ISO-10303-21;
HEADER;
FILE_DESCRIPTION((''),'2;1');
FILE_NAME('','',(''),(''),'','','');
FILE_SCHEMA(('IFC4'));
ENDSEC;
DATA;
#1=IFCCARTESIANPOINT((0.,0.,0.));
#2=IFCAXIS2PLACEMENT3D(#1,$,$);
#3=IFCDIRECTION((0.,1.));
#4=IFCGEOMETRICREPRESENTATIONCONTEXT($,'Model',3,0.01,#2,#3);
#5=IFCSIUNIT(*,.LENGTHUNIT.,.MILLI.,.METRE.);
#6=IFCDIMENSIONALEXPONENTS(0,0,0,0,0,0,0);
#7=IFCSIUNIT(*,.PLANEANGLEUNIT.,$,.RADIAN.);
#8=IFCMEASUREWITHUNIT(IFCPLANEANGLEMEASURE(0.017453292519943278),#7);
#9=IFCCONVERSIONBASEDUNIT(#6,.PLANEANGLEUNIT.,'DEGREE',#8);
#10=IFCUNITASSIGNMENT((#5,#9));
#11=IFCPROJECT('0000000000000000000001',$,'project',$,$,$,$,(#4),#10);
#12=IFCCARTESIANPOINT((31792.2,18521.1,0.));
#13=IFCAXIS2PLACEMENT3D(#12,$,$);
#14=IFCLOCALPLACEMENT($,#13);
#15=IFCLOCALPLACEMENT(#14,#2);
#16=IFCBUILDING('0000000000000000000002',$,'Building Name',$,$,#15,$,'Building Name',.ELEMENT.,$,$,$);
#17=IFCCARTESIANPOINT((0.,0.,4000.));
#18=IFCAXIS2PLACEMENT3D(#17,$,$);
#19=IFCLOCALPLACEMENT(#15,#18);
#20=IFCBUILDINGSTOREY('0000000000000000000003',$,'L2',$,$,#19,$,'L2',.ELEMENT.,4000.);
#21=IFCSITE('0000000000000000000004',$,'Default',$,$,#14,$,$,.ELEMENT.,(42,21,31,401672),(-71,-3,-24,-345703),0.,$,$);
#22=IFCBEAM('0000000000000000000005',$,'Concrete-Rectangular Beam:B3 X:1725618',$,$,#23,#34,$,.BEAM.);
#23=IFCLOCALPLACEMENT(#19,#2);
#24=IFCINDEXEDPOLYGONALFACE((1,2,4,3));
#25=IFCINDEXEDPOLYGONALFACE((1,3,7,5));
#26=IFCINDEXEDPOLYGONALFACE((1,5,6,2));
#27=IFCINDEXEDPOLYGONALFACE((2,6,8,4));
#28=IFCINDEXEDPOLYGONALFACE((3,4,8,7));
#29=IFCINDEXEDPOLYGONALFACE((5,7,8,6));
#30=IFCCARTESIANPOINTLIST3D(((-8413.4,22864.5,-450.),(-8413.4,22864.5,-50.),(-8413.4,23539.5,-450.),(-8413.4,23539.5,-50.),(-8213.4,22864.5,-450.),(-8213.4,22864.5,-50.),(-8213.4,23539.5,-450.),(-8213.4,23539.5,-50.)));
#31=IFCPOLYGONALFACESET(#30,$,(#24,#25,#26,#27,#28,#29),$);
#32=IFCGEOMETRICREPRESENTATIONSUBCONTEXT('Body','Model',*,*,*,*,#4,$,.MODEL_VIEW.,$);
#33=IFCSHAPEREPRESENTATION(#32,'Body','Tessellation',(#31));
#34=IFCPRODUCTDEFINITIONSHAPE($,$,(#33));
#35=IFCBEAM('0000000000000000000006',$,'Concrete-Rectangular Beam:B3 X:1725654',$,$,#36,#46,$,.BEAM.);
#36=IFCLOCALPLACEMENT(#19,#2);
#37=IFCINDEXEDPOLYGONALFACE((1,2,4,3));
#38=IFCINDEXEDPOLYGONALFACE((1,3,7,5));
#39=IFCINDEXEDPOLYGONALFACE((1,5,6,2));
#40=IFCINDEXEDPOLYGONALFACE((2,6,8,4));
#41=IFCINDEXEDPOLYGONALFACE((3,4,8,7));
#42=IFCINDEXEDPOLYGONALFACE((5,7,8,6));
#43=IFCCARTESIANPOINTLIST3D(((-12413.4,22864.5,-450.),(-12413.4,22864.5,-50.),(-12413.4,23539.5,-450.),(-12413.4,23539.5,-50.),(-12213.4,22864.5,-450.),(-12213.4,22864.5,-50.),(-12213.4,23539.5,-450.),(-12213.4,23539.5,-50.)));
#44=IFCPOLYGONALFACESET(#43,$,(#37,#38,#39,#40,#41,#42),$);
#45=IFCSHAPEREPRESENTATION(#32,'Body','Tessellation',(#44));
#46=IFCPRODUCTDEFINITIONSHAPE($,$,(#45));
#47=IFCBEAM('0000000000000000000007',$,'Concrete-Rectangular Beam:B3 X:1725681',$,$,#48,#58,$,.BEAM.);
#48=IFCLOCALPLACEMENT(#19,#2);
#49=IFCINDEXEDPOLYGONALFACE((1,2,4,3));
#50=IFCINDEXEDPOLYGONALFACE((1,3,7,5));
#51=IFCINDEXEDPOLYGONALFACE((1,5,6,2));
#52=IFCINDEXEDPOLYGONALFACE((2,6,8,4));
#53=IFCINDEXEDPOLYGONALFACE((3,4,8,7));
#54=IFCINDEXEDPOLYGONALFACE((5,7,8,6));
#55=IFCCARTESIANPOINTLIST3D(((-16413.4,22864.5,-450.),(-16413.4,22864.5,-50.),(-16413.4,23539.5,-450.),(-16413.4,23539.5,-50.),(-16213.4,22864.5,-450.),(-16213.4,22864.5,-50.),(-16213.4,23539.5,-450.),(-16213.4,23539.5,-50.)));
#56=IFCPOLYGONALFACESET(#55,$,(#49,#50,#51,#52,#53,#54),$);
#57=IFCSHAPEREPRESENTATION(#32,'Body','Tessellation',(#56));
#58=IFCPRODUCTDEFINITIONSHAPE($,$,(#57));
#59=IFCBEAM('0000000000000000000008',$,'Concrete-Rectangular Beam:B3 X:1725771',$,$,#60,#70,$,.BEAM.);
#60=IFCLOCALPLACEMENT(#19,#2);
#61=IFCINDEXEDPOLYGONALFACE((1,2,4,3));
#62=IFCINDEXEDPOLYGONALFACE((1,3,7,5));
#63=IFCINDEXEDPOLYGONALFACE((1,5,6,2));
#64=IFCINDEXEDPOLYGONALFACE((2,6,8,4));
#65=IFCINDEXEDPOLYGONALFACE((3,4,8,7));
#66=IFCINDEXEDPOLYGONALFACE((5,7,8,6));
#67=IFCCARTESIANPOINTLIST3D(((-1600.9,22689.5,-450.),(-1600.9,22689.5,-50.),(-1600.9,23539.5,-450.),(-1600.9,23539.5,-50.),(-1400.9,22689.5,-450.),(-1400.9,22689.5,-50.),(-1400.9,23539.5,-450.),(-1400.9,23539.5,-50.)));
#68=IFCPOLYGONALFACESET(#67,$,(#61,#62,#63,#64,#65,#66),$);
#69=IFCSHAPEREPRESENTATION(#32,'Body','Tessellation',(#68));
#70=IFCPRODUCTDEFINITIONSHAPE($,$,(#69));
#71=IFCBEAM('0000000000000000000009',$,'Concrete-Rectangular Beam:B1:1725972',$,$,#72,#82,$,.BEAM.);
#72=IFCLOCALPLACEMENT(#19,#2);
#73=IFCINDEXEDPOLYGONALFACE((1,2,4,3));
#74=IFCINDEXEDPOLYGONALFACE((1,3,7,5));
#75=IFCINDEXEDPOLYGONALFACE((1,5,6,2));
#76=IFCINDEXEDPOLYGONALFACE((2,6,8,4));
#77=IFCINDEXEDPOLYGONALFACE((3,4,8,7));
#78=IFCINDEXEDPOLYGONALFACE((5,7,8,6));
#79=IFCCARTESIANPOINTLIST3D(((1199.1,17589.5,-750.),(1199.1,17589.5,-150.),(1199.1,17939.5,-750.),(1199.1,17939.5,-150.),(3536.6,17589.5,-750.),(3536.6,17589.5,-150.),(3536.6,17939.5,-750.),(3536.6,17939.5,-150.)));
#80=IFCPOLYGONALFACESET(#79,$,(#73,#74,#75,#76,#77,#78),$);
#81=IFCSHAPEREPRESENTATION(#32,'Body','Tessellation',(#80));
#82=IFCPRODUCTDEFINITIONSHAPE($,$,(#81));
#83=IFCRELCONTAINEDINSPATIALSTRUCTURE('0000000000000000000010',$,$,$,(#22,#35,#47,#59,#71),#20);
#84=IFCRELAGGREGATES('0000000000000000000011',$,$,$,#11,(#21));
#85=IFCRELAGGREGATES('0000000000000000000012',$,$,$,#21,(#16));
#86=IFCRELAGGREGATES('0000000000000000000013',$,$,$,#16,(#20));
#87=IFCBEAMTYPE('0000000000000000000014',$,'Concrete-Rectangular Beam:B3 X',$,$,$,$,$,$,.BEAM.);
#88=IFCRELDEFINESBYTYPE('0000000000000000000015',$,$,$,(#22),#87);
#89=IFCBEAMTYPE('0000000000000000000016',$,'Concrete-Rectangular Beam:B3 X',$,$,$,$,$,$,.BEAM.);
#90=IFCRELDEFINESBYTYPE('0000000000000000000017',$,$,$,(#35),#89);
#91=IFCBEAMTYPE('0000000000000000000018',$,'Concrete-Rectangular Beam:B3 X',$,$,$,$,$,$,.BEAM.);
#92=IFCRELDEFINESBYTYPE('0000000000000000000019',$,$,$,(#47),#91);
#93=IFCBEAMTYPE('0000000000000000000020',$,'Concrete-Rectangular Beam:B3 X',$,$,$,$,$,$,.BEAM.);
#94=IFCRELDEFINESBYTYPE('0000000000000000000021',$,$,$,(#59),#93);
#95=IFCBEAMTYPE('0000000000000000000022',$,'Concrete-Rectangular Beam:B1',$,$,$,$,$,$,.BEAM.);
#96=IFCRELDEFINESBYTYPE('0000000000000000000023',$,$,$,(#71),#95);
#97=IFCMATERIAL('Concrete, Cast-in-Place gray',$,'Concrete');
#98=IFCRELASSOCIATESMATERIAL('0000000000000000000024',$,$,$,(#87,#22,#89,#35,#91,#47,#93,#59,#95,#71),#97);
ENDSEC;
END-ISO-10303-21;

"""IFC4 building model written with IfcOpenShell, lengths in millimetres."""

from ifc_helpers import new_model, entity, si_unit, converted_unit, direction, frame, origin, place, context, subcontext, project, spatial, indexed_curve, outline, extrude, source, transform, mapped, material, type_object, type_shapes, element, save


model = new_model("IFC4")

# Units and contexts
model_context = context("Model", 3, precision=0.01, world=origin(), true_north=direction((0.0, 1.0)))
body_context = subcontext(model_context, "Body", "Model", "MODEL_VIEW")
ifc_project = project(units=[si_unit("LENGTHUNIT", "METRE", prefix="MILLI"), converted_unit("PLANEANGLEUNIT", "DEGREE", entity("IfcPlaneAngleMeasure", 0.017453292519943278), si_unit("PLANEANGLEUNIT", "RADIAN"), dimensions=[0, 0, 0, 0, 0, 0, 0])], contexts=[model_context])

# Site, building, storey
site_placement = place(None, frame((31792.2, 18521.1, 0.0)))
site = spatial("IfcSite", under=ifc_project, at=site_placement, Name="Default", CompositionType="ELEMENT", RefLatitude=(42, 21, 31, 401672), RefLongitude=(-71, -3, -24, -345703), RefElevation=0.0)
building_placement = place(site_placement, origin())
building = spatial("IfcBuilding", under=site, at=building_placement, Name="Building Name", LongName="Building Name", CompositionType="ELEMENT")
storey_placement = place(building_placement, frame((0.0, 0.0, 4000.0)))
storey = spatial("IfcBuildingStorey", under=building, at=storey_placement, Name="L2", LongName="L2", CompositionType="ELEMENT", Elevation=4000.0)

# Shared definitions
ifc_material = material(Name="Concrete, Cast-in-Place gray", Category="Concrete")

# Beams
beam_type_1 = type_object("IfcBeamType", Name="Concrete-Rectangular Beam:B3 X", PredefinedType="BEAM", material=ifc_material)
shared_shape_1 = source(origin(), body_context, "Body", "SweptSolid", [
    extrude(outline(indexed_curve([(-100.0, -200.0), (100.0, -200.0), (100.0, 200.0), (-100.0, 200.0), (-100.0, -200.0)], self_intersect=False)), frame((-8313.4, 23539.5, 3750.0), z_axis=(0.0, -1.0, 0.0), x_axis=(-1.0, 0.0, 0.0)), (0.0, 0.0, 1.0), 675.0),
])
type_shapes(beam_type_1, [shared_shape_1])
beam_1_placement = place(storey_placement, frame((0.0, 0.0, -4000.0)))
element("IfcBeam", 1, at=beam_1_placement, inside=storey, type_object=beam_type_1, material=ifc_material, Name="Concrete-Rectangular Beam:B3 X:1725618", PredefinedType="BEAM", context=body_context, shape_type="MappedRepresentation", body=[
    mapped(shared_shape_1, transform((0.0, 0.0, 0.0), scale=1.0)),
])
beam_type_2 = type_object("IfcBeamType", Name="Concrete-Rectangular Beam:B3 X", PredefinedType="BEAM", material=ifc_material)
shared_shape_2 = source(origin(), body_context, "Body", "SweptSolid", [
    extrude(outline(indexed_curve([(-100.0, -200.0), (100.0, -200.0), (100.0, 200.0), (-100.0, 200.0), (-100.0, -200.0)], self_intersect=False)), frame((-12313.4, 23539.5, 3750.0), z_axis=(0.0, -1.0, 0.0), x_axis=(-1.0, 0.0, 0.0)), (0.0, 0.0, 1.0), 675.0),
])
type_shapes(beam_type_2, [shared_shape_2])
beam_2_placement = place(storey_placement, frame((0.0, 0.0, -4000.0)))
element("IfcBeam", 2, at=beam_2_placement, inside=storey, type_object=beam_type_2, material=ifc_material, Name="Concrete-Rectangular Beam:B3 X:1725654", PredefinedType="BEAM", context=body_context, shape_type="MappedRepresentation", body=[
    mapped(shared_shape_2, transform((0.0, 0.0, 0.0), scale=1.0)),
])
beam_type_3 = type_object("IfcBeamType", Name="Concrete-Rectangular Beam:B3 X", PredefinedType="BEAM", material=ifc_material)
shared_shape_3 = source(origin(), body_context, "Body", "SweptSolid", [
    extrude(outline(indexed_curve([(-100.0, -200.0), (100.0, -200.0), (100.0, 200.0), (-100.0, 200.0), (-100.0, -200.0)], self_intersect=False)), frame((-16313.4, 23539.5, 3750.0), z_axis=(0.0, -1.0, 0.0), x_axis=(-1.0, 0.0, 0.0)), (0.0, 0.0, 1.0), 675.0),
])
type_shapes(beam_type_3, [shared_shape_3])
beam_3_placement = place(storey_placement, frame((0.0, 0.0, -4000.0)))
element("IfcBeam", 3, at=beam_3_placement, inside=storey, type_object=beam_type_3, material=ifc_material, Name="Concrete-Rectangular Beam:B3 X:1725681", PredefinedType="BEAM", context=body_context, shape_type="MappedRepresentation", body=[
    mapped(shared_shape_3, transform((0.0, 0.0, 0.0), scale=1.0)),
])
beam_type_4 = type_object("IfcBeamType", Name="Concrete-Rectangular Beam:B3 X", PredefinedType="BEAM", material=ifc_material)
shared_shape_4 = source(origin(), body_context, "Body", "SweptSolid", [
    extrude(outline(indexed_curve([(-100.0, -200.0), (100.0, -200.0), (100.0, 200.0), (-100.0, 200.0), (-100.0, -200.0)], self_intersect=False)), frame((-1500.9, 22689.5, 3750.0), z_axis=(0.0, 1.0, 0.0), x_axis=(-1.0, 0.0, 0.0)), (0.0, 0.0, 1.0), 850.0),
])
type_shapes(beam_type_4, [shared_shape_4])
beam_4_placement = place(storey_placement, frame((0.0, 0.0, -4000.0)))
element("IfcBeam", 4, at=beam_4_placement, inside=storey, type_object=beam_type_4, material=ifc_material, Name="Concrete-Rectangular Beam:B3 X:1725771", PredefinedType="BEAM", context=body_context, shape_type="MappedRepresentation", body=[
    mapped(shared_shape_4, transform((0.0, 0.0, 0.0), scale=1.0)),
])
beam_type_5 = type_object("IfcBeamType", Name="Concrete-Rectangular Beam:B1", PredefinedType="BEAM", material=ifc_material)
shared_shape_5 = source(origin(), body_context, "Body", "SweptSolid", [
    extrude(outline(indexed_curve([(-300.0, -175.0), (300.0, -175.0), (300.0, 175.0), (-300.0, 175.0), (-300.0, -175.0)], self_intersect=False)), frame((1199.1, 17764.5, 3550.0), z_axis=(1.0, 0.0, 0.0), x_axis=(0.0, 0.0, -1.0)), (0.0, 0.0, 1.0), 2337.5),
])
type_shapes(beam_type_5, [shared_shape_5])
beam_5_placement = place(storey_placement, frame((0.0, 0.0, -4000.0)))
element("IfcBeam", 5, at=beam_5_placement, inside=storey, type_object=beam_type_5, material=ifc_material, Name="Concrete-Rectangular Beam:B1:1725972", PredefinedType="BEAM", context=body_context, shape_type="MappedRepresentation", body=[
    mapped(shared_shape_5, transform((0.0, 0.0, 0.0), scale=1.0)),
])

save(model, "model.ifc")
